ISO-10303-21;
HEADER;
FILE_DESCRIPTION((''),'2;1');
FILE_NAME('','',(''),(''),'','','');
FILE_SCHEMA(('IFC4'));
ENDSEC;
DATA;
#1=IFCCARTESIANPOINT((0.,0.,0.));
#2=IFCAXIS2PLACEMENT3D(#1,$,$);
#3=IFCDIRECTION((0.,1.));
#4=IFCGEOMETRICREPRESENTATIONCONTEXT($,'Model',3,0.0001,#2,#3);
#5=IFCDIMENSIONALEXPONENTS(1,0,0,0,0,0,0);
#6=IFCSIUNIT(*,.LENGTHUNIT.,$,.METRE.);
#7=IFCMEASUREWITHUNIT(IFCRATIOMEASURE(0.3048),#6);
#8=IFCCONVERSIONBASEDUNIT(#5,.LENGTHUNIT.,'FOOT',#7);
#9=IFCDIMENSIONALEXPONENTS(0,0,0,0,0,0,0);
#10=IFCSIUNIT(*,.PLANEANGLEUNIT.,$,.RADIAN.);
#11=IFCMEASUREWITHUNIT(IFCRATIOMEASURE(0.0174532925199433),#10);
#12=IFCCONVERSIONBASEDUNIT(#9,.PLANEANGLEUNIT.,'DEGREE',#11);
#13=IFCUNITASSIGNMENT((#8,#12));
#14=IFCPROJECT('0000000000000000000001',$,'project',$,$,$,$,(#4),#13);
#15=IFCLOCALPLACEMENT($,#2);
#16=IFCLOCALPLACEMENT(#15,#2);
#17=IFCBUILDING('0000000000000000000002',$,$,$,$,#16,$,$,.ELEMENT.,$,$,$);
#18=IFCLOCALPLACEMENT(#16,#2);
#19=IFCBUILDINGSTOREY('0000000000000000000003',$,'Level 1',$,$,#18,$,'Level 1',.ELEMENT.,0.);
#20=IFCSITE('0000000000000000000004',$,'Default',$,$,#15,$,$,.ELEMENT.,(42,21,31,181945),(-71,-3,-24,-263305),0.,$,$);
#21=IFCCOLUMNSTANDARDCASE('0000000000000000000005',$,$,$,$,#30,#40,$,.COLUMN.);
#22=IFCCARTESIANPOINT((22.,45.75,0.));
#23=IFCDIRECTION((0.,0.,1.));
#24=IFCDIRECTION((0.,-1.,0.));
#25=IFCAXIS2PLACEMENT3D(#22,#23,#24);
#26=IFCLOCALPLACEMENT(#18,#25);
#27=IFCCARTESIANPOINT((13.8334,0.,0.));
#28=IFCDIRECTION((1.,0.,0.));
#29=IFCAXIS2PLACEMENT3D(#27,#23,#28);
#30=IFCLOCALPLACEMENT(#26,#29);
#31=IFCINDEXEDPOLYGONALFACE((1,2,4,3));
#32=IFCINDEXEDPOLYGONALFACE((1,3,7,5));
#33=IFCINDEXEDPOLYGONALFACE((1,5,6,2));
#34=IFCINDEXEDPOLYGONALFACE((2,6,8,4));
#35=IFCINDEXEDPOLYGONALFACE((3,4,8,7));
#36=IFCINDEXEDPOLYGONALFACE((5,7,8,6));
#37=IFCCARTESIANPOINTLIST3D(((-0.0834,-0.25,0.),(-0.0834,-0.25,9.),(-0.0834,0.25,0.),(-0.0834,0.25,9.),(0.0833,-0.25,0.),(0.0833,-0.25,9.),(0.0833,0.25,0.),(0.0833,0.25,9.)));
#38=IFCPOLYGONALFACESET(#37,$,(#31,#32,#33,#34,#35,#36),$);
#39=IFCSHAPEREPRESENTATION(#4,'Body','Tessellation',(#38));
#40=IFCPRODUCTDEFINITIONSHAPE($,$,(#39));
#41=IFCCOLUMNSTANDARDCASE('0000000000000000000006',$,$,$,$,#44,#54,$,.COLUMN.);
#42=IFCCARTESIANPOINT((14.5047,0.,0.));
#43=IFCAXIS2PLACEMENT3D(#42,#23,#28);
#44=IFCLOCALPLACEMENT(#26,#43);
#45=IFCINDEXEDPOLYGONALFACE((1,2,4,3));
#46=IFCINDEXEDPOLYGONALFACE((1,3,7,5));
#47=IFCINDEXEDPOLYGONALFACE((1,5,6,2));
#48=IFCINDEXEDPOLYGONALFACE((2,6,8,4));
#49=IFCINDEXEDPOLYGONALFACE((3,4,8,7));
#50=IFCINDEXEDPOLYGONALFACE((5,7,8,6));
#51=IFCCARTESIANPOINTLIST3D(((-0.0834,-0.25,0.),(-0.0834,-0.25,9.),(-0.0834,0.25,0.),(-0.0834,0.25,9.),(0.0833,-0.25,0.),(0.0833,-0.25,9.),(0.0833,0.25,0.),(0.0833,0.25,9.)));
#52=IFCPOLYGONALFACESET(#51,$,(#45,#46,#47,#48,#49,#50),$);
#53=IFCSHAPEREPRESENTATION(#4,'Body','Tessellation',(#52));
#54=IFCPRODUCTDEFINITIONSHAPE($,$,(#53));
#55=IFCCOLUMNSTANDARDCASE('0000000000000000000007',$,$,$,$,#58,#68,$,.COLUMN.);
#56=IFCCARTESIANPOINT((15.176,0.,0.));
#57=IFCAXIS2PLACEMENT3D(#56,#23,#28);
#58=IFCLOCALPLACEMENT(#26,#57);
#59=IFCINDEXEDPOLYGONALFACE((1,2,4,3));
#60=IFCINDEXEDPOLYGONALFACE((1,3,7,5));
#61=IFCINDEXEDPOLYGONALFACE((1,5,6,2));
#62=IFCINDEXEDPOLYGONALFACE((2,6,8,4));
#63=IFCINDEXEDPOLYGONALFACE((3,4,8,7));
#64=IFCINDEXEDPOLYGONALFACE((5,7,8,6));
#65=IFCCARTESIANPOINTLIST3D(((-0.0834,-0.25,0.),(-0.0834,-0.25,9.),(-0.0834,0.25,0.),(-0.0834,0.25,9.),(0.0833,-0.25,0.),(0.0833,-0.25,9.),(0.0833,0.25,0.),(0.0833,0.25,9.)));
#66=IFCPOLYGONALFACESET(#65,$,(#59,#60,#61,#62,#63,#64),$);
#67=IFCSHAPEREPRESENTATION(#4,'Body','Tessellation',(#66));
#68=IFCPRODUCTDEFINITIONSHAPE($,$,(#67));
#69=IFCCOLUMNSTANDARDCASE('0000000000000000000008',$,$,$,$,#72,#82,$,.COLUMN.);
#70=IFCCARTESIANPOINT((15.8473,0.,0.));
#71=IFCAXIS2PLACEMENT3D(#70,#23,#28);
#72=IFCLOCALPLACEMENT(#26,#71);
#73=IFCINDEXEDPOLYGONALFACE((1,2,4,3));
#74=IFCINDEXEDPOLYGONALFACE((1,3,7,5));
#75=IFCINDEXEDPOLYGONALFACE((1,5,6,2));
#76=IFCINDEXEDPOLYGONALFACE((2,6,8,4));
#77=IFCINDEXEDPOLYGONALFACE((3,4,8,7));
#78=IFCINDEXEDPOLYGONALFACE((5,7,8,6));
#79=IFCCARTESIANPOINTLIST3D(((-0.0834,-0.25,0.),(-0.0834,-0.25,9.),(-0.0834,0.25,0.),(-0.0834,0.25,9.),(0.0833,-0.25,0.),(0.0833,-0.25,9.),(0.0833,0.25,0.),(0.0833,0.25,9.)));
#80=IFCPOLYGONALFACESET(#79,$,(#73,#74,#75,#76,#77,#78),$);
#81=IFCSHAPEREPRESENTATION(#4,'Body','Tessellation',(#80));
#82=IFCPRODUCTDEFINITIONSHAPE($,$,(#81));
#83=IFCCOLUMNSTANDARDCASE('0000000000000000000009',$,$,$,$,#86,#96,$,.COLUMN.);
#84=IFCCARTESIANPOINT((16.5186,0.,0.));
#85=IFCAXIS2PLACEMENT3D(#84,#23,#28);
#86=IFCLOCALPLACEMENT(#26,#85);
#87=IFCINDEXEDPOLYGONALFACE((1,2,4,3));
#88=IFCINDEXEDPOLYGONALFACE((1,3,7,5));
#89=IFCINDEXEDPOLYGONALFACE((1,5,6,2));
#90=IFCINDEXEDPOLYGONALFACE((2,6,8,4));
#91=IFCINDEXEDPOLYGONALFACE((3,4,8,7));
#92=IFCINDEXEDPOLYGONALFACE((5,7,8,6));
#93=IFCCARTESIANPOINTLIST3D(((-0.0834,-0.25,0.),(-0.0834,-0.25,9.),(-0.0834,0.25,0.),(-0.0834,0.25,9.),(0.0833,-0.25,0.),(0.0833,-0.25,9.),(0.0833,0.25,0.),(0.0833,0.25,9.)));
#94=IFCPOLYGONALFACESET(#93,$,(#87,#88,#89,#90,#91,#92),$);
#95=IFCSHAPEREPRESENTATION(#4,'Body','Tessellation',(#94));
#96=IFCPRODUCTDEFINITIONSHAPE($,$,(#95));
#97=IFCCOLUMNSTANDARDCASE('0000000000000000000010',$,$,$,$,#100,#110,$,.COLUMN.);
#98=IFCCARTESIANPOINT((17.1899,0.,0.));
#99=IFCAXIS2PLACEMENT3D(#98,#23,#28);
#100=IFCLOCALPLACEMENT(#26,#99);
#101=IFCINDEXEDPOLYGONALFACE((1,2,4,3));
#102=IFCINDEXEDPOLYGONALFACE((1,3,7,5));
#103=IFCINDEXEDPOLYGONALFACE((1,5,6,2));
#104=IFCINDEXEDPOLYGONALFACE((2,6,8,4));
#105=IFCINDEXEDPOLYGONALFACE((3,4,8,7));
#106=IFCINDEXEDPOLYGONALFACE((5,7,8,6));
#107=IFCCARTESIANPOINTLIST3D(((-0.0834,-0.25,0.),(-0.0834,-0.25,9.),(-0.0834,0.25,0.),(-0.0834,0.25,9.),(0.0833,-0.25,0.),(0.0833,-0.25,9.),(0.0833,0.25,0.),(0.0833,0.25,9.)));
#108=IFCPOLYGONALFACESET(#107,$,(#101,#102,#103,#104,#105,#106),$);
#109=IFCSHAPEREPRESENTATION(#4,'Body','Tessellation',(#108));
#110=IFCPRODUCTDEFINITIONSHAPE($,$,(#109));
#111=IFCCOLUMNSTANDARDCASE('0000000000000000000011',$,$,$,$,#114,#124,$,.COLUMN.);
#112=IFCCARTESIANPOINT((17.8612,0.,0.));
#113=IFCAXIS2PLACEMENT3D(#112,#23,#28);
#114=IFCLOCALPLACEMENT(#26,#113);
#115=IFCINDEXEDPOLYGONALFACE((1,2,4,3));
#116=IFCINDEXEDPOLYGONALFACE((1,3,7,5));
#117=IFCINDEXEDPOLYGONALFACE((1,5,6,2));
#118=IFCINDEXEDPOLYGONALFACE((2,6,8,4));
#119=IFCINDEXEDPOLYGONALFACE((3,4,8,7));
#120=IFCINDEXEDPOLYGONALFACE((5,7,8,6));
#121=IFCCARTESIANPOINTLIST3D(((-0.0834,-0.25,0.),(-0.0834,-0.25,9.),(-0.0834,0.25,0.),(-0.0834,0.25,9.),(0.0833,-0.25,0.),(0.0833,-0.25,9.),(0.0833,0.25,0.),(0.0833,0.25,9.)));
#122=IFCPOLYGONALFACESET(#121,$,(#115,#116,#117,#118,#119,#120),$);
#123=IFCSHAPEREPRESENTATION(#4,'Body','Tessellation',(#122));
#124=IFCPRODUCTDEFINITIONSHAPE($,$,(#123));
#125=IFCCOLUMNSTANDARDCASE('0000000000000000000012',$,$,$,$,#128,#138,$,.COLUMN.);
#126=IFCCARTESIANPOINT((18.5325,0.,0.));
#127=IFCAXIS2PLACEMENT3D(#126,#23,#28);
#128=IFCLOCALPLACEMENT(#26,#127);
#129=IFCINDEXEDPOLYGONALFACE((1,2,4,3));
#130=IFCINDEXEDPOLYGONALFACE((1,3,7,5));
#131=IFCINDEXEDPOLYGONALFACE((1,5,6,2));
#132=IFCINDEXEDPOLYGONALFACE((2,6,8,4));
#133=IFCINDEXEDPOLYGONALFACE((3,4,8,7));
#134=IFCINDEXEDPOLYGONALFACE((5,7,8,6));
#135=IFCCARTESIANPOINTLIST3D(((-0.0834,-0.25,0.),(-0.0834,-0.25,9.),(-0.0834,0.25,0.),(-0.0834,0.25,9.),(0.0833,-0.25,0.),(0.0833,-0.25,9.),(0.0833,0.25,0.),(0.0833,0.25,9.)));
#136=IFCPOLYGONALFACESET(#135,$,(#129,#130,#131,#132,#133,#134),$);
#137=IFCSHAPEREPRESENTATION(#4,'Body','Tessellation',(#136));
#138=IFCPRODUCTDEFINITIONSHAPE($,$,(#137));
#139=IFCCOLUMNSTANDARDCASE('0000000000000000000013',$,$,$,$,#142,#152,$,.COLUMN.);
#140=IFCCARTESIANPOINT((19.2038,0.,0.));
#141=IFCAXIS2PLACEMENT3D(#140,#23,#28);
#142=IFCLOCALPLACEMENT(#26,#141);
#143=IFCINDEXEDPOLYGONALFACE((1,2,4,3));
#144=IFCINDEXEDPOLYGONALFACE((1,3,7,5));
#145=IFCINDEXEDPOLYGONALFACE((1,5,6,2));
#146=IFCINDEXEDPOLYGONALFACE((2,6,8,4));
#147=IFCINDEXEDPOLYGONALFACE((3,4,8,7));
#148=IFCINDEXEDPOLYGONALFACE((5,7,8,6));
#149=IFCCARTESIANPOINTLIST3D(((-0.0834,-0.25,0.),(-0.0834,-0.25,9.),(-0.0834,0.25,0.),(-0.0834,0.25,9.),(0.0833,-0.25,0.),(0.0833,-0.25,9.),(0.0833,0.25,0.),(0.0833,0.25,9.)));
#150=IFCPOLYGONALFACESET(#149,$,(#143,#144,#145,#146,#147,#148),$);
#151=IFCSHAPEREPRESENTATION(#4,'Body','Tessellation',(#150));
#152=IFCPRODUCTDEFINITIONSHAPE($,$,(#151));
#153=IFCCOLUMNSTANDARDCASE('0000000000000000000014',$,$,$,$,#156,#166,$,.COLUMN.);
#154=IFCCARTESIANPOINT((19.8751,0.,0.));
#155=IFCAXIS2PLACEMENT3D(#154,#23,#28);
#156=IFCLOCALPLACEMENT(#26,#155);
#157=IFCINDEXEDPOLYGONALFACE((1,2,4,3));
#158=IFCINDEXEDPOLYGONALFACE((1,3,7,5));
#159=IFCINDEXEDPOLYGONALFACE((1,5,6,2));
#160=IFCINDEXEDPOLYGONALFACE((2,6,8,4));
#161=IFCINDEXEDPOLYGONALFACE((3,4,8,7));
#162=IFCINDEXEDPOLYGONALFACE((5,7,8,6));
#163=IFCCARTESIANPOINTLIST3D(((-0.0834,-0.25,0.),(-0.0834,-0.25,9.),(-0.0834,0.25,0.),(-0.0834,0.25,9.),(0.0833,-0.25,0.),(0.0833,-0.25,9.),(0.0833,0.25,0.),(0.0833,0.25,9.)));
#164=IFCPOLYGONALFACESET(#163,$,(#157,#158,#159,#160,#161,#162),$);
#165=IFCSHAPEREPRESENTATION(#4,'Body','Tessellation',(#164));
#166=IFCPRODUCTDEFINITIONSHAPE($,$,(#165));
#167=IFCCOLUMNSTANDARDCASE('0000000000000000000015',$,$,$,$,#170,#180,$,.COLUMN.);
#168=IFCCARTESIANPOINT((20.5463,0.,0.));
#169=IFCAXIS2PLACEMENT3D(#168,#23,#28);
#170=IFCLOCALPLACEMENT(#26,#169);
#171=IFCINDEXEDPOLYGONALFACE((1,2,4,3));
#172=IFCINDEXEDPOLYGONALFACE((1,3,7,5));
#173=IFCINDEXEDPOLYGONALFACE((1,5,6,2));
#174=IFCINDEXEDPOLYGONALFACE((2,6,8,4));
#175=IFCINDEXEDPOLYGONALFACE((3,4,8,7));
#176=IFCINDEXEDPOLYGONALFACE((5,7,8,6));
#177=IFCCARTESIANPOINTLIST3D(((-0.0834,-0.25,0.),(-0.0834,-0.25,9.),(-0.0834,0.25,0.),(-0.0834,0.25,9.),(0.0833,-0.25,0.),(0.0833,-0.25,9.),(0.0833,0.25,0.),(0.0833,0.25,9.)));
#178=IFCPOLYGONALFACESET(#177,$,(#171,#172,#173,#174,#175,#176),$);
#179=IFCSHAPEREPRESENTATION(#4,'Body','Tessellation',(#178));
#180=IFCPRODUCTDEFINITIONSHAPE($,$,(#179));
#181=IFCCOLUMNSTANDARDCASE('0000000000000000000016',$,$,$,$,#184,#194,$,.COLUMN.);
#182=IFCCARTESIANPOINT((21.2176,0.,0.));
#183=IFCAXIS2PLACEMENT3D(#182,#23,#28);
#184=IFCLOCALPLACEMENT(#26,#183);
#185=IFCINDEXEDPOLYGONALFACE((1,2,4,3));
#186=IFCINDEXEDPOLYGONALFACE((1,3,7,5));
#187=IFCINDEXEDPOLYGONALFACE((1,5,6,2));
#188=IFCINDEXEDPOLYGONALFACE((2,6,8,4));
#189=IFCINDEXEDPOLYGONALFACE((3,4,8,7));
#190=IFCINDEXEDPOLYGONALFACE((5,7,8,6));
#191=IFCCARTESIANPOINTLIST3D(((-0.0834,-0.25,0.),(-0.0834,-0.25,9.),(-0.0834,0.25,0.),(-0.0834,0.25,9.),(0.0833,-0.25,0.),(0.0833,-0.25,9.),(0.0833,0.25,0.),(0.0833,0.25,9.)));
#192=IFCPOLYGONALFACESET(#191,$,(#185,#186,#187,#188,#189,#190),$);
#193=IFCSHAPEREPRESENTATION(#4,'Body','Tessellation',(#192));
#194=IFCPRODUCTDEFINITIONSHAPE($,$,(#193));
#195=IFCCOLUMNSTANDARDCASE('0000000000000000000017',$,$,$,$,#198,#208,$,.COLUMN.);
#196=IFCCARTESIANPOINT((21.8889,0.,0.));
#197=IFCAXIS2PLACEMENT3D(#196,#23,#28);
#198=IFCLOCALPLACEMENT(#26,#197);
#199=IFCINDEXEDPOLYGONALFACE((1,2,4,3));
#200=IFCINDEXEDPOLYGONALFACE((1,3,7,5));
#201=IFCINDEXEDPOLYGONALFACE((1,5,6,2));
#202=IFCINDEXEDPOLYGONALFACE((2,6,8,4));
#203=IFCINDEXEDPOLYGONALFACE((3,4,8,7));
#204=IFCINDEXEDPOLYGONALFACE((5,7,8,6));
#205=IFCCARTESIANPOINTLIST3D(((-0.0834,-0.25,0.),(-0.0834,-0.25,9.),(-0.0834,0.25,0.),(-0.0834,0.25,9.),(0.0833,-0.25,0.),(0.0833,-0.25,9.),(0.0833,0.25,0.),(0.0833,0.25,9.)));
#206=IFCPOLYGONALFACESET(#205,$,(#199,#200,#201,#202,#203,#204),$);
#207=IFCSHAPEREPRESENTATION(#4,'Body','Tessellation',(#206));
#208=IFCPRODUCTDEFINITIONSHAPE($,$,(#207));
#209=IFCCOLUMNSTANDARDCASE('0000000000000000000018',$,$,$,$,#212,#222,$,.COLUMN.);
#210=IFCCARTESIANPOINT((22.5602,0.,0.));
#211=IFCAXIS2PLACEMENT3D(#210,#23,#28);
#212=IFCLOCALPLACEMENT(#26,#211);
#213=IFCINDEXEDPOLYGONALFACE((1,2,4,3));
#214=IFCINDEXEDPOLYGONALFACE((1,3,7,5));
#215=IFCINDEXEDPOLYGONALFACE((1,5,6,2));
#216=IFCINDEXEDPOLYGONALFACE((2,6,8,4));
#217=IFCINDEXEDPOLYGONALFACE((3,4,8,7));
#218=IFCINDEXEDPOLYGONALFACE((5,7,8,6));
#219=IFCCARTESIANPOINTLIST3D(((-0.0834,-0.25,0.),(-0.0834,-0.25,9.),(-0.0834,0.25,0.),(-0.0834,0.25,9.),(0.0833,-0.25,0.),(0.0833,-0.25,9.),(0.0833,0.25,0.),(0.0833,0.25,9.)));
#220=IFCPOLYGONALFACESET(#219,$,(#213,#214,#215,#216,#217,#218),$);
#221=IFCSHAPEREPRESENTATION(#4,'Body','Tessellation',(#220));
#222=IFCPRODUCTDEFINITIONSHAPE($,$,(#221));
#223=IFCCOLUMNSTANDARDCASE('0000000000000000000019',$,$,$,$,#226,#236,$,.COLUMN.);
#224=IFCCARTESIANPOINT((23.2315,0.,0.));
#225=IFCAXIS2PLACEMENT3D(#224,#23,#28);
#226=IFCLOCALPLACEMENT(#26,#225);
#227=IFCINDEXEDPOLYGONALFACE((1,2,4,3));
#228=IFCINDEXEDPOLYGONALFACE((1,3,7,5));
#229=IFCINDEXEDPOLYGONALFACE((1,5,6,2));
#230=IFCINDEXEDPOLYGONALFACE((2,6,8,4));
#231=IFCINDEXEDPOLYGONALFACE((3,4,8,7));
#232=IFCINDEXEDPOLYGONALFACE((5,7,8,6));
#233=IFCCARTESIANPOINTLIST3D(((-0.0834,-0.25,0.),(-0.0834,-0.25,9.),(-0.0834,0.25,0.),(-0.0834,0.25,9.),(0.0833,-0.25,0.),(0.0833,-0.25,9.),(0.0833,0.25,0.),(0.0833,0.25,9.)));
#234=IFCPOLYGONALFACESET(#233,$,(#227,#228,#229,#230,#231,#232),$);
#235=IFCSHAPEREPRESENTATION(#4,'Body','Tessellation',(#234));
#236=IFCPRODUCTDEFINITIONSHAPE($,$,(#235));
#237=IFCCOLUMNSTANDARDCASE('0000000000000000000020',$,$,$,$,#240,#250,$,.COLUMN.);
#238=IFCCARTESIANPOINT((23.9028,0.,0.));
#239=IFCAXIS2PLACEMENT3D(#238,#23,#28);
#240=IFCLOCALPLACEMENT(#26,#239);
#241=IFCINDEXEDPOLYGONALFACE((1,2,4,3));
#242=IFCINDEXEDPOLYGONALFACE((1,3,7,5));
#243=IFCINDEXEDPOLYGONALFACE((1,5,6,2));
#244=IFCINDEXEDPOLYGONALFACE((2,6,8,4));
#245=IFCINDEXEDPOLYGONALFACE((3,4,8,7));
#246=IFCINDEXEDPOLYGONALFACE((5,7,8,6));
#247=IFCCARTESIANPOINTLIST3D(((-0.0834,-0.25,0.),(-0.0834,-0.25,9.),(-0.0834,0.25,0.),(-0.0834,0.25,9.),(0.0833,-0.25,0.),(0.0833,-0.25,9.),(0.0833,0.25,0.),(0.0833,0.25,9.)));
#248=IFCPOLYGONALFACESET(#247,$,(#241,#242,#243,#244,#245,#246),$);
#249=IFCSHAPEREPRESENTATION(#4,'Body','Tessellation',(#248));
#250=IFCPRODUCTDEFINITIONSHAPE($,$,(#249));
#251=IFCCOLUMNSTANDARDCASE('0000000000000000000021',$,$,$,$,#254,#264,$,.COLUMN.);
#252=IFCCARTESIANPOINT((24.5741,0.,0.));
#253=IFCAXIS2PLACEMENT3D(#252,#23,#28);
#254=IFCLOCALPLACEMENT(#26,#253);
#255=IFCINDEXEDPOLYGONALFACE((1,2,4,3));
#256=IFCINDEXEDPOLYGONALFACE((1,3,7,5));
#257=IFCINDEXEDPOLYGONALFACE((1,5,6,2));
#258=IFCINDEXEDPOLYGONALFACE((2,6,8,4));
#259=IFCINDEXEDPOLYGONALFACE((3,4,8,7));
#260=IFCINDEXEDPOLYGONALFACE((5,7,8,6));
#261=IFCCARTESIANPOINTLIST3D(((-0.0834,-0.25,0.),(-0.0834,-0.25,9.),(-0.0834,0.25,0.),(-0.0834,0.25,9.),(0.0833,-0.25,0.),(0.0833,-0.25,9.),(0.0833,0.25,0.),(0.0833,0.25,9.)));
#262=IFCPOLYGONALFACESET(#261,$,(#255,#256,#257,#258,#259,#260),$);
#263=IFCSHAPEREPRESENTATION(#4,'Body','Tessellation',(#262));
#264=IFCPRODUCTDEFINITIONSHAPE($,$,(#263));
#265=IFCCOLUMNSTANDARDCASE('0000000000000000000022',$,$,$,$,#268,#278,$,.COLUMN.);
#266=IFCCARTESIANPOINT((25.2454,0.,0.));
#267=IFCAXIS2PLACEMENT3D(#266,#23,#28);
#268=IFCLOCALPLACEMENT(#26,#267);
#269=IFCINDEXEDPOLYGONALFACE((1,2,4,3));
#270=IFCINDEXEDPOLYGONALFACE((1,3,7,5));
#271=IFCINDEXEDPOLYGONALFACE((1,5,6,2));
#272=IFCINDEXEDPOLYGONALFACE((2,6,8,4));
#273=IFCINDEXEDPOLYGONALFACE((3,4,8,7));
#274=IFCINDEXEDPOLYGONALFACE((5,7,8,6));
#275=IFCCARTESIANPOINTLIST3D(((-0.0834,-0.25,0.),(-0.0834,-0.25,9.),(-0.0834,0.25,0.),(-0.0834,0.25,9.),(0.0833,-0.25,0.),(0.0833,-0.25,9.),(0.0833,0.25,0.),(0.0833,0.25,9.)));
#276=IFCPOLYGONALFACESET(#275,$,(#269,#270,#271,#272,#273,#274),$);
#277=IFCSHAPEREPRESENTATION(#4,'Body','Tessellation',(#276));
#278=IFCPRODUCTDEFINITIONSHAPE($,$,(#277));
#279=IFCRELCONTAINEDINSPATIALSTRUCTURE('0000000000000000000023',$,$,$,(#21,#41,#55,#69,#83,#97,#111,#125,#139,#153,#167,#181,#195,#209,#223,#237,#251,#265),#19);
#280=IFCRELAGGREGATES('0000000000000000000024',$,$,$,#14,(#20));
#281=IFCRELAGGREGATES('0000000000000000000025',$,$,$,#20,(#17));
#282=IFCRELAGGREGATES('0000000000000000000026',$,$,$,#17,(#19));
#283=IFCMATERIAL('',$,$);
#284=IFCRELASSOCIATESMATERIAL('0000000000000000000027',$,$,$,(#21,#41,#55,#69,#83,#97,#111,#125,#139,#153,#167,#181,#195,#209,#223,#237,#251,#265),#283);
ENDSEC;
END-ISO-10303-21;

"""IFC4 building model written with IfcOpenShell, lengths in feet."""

from ifc_helpers import new_model, entity, si_unit, converted_unit, direction, frame, origin, place, context, project, spatial, rectangle, extrude, material, element, save


model = new_model("IFC4")

# Units and contexts
model_context = context("Model", 3, precision=0.0001, world=origin(), true_north=direction((0.0, 1.0)))
ifc_project = project(units=[converted_unit("LENGTHUNIT", "FOOT", entity("IfcRatioMeasure", 0.3048), si_unit("LENGTHUNIT", "METRE"), dimensions=[1, 0, 0, 0, 0, 0, 0]), converted_unit("PLANEANGLEUNIT", "DEGREE", entity("IfcRatioMeasure", 0.0174532925199433), si_unit("PLANEANGLEUNIT", "RADIAN"), dimensions=[0, 0, 0, 0, 0, 0, 0])], contexts=[model_context])

# Site, building, storey
site_placement = place(None, origin())
site = spatial("IfcSite", under=ifc_project, at=site_placement, Name="Default", CompositionType="ELEMENT", RefLatitude=(42, 21, 31, 181945), RefLongitude=(-71, -3, -24, -263305), RefElevation=0.0)
building_placement = place(site_placement, origin())
building = spatial("IfcBuilding", under=site, at=building_placement, CompositionType="ELEMENT")
storey_placement = place(building_placement, origin())
storey = spatial("IfcBuildingStorey", under=building, at=storey_placement, Name="Level 1", LongName="Level 1", CompositionType="ELEMENT", Elevation=0.0)

# Columns
ifc_material_1 = material(Name="")
placement_1 = place(storey_placement, frame((22.0, 45.75, 0.0), z_axis=(0.0, 0.0, 1.0), x_axis=(0.0, -1.0, 0.0)))
for number, where, z_axis, x_axis in (
    (1, (13.8334, 0.0, 0.0), (0.0, 0.0, 1.0), (1.0, 0.0, 0.0)),
    (2, (14.5047, 0.0, 0.0), (0.0, 0.0, 1.0), (1.0, 0.0, 0.0)),
    (3, (15.176, 0.0, 0.0), (0.0, 0.0, 1.0), (1.0, 0.0, 0.0)),
    (4, (15.8473, 0.0, 0.0), (0.0, 0.0, 1.0), (1.0, 0.0, 0.0)),
    (5, (16.5186, 0.0, 0.0), (0.0, 0.0, 1.0), (1.0, 0.0, 0.0)),
    (6, (17.1899, 0.0, 0.0), (0.0, 0.0, 1.0), (1.0, 0.0, 0.0)),
    (7, (17.8612, 0.0, 0.0), (0.0, 0.0, 1.0), (1.0, 0.0, 0.0)),
    (8, (18.5325, 0.0, 0.0), (0.0, 0.0, 1.0), (1.0, 0.0, 0.0)),
    (9, (19.2038, 0.0, 0.0), (0.0, 0.0, 1.0), (1.0, 0.0, 0.0)),
    (10, (19.8751, 0.0, 0.0), (0.0, 0.0, 1.0), (1.0, 0.0, 0.0)),
    (11, (20.5463, 0.0, 0.0), (0.0, 0.0, 1.0), (1.0, 0.0, 0.0)),
    (12, (21.2176, 0.0, 0.0), (0.0, 0.0, 1.0), (1.0, 0.0, 0.0)),
    (13, (21.8889, 0.0, 0.0), (0.0, 0.0, 1.0), (1.0, 0.0, 0.0)),
    (14, (22.5602, 0.0, 0.0), (0.0, 0.0, 1.0), (1.0, 0.0, 0.0)),
    (15, (23.2315, 0.0, 0.0), (0.0, 0.0, 1.0), (1.0, 0.0, 0.0)),
    (16, (23.9028, 0.0, 0.0), (0.0, 0.0, 1.0), (1.0, 0.0, 0.0)),
    (17, (24.5741, 0.0, 0.0), (0.0, 0.0, 1.0), (1.0, 0.0, 0.0)),
    (18, (25.2454, 0.0, 0.0), (0.0, 0.0, 1.0), (1.0, 0.0, 0.0)),
):
    element("IfcColumnStandardCase", number, at=place(placement_1, frame(where, z_axis=z_axis, x_axis=x_axis)), inside=storey, material=ifc_material_1, PredefinedType="COLUMN", context=model_context, shape_type="SweptSolid", body=[
        extrude(rectangle(XDim=0.1667, YDim=0.5), origin(), (0.0, 0.0, 1.0), 9.0),
    ])

save(model, "model.ifc")
